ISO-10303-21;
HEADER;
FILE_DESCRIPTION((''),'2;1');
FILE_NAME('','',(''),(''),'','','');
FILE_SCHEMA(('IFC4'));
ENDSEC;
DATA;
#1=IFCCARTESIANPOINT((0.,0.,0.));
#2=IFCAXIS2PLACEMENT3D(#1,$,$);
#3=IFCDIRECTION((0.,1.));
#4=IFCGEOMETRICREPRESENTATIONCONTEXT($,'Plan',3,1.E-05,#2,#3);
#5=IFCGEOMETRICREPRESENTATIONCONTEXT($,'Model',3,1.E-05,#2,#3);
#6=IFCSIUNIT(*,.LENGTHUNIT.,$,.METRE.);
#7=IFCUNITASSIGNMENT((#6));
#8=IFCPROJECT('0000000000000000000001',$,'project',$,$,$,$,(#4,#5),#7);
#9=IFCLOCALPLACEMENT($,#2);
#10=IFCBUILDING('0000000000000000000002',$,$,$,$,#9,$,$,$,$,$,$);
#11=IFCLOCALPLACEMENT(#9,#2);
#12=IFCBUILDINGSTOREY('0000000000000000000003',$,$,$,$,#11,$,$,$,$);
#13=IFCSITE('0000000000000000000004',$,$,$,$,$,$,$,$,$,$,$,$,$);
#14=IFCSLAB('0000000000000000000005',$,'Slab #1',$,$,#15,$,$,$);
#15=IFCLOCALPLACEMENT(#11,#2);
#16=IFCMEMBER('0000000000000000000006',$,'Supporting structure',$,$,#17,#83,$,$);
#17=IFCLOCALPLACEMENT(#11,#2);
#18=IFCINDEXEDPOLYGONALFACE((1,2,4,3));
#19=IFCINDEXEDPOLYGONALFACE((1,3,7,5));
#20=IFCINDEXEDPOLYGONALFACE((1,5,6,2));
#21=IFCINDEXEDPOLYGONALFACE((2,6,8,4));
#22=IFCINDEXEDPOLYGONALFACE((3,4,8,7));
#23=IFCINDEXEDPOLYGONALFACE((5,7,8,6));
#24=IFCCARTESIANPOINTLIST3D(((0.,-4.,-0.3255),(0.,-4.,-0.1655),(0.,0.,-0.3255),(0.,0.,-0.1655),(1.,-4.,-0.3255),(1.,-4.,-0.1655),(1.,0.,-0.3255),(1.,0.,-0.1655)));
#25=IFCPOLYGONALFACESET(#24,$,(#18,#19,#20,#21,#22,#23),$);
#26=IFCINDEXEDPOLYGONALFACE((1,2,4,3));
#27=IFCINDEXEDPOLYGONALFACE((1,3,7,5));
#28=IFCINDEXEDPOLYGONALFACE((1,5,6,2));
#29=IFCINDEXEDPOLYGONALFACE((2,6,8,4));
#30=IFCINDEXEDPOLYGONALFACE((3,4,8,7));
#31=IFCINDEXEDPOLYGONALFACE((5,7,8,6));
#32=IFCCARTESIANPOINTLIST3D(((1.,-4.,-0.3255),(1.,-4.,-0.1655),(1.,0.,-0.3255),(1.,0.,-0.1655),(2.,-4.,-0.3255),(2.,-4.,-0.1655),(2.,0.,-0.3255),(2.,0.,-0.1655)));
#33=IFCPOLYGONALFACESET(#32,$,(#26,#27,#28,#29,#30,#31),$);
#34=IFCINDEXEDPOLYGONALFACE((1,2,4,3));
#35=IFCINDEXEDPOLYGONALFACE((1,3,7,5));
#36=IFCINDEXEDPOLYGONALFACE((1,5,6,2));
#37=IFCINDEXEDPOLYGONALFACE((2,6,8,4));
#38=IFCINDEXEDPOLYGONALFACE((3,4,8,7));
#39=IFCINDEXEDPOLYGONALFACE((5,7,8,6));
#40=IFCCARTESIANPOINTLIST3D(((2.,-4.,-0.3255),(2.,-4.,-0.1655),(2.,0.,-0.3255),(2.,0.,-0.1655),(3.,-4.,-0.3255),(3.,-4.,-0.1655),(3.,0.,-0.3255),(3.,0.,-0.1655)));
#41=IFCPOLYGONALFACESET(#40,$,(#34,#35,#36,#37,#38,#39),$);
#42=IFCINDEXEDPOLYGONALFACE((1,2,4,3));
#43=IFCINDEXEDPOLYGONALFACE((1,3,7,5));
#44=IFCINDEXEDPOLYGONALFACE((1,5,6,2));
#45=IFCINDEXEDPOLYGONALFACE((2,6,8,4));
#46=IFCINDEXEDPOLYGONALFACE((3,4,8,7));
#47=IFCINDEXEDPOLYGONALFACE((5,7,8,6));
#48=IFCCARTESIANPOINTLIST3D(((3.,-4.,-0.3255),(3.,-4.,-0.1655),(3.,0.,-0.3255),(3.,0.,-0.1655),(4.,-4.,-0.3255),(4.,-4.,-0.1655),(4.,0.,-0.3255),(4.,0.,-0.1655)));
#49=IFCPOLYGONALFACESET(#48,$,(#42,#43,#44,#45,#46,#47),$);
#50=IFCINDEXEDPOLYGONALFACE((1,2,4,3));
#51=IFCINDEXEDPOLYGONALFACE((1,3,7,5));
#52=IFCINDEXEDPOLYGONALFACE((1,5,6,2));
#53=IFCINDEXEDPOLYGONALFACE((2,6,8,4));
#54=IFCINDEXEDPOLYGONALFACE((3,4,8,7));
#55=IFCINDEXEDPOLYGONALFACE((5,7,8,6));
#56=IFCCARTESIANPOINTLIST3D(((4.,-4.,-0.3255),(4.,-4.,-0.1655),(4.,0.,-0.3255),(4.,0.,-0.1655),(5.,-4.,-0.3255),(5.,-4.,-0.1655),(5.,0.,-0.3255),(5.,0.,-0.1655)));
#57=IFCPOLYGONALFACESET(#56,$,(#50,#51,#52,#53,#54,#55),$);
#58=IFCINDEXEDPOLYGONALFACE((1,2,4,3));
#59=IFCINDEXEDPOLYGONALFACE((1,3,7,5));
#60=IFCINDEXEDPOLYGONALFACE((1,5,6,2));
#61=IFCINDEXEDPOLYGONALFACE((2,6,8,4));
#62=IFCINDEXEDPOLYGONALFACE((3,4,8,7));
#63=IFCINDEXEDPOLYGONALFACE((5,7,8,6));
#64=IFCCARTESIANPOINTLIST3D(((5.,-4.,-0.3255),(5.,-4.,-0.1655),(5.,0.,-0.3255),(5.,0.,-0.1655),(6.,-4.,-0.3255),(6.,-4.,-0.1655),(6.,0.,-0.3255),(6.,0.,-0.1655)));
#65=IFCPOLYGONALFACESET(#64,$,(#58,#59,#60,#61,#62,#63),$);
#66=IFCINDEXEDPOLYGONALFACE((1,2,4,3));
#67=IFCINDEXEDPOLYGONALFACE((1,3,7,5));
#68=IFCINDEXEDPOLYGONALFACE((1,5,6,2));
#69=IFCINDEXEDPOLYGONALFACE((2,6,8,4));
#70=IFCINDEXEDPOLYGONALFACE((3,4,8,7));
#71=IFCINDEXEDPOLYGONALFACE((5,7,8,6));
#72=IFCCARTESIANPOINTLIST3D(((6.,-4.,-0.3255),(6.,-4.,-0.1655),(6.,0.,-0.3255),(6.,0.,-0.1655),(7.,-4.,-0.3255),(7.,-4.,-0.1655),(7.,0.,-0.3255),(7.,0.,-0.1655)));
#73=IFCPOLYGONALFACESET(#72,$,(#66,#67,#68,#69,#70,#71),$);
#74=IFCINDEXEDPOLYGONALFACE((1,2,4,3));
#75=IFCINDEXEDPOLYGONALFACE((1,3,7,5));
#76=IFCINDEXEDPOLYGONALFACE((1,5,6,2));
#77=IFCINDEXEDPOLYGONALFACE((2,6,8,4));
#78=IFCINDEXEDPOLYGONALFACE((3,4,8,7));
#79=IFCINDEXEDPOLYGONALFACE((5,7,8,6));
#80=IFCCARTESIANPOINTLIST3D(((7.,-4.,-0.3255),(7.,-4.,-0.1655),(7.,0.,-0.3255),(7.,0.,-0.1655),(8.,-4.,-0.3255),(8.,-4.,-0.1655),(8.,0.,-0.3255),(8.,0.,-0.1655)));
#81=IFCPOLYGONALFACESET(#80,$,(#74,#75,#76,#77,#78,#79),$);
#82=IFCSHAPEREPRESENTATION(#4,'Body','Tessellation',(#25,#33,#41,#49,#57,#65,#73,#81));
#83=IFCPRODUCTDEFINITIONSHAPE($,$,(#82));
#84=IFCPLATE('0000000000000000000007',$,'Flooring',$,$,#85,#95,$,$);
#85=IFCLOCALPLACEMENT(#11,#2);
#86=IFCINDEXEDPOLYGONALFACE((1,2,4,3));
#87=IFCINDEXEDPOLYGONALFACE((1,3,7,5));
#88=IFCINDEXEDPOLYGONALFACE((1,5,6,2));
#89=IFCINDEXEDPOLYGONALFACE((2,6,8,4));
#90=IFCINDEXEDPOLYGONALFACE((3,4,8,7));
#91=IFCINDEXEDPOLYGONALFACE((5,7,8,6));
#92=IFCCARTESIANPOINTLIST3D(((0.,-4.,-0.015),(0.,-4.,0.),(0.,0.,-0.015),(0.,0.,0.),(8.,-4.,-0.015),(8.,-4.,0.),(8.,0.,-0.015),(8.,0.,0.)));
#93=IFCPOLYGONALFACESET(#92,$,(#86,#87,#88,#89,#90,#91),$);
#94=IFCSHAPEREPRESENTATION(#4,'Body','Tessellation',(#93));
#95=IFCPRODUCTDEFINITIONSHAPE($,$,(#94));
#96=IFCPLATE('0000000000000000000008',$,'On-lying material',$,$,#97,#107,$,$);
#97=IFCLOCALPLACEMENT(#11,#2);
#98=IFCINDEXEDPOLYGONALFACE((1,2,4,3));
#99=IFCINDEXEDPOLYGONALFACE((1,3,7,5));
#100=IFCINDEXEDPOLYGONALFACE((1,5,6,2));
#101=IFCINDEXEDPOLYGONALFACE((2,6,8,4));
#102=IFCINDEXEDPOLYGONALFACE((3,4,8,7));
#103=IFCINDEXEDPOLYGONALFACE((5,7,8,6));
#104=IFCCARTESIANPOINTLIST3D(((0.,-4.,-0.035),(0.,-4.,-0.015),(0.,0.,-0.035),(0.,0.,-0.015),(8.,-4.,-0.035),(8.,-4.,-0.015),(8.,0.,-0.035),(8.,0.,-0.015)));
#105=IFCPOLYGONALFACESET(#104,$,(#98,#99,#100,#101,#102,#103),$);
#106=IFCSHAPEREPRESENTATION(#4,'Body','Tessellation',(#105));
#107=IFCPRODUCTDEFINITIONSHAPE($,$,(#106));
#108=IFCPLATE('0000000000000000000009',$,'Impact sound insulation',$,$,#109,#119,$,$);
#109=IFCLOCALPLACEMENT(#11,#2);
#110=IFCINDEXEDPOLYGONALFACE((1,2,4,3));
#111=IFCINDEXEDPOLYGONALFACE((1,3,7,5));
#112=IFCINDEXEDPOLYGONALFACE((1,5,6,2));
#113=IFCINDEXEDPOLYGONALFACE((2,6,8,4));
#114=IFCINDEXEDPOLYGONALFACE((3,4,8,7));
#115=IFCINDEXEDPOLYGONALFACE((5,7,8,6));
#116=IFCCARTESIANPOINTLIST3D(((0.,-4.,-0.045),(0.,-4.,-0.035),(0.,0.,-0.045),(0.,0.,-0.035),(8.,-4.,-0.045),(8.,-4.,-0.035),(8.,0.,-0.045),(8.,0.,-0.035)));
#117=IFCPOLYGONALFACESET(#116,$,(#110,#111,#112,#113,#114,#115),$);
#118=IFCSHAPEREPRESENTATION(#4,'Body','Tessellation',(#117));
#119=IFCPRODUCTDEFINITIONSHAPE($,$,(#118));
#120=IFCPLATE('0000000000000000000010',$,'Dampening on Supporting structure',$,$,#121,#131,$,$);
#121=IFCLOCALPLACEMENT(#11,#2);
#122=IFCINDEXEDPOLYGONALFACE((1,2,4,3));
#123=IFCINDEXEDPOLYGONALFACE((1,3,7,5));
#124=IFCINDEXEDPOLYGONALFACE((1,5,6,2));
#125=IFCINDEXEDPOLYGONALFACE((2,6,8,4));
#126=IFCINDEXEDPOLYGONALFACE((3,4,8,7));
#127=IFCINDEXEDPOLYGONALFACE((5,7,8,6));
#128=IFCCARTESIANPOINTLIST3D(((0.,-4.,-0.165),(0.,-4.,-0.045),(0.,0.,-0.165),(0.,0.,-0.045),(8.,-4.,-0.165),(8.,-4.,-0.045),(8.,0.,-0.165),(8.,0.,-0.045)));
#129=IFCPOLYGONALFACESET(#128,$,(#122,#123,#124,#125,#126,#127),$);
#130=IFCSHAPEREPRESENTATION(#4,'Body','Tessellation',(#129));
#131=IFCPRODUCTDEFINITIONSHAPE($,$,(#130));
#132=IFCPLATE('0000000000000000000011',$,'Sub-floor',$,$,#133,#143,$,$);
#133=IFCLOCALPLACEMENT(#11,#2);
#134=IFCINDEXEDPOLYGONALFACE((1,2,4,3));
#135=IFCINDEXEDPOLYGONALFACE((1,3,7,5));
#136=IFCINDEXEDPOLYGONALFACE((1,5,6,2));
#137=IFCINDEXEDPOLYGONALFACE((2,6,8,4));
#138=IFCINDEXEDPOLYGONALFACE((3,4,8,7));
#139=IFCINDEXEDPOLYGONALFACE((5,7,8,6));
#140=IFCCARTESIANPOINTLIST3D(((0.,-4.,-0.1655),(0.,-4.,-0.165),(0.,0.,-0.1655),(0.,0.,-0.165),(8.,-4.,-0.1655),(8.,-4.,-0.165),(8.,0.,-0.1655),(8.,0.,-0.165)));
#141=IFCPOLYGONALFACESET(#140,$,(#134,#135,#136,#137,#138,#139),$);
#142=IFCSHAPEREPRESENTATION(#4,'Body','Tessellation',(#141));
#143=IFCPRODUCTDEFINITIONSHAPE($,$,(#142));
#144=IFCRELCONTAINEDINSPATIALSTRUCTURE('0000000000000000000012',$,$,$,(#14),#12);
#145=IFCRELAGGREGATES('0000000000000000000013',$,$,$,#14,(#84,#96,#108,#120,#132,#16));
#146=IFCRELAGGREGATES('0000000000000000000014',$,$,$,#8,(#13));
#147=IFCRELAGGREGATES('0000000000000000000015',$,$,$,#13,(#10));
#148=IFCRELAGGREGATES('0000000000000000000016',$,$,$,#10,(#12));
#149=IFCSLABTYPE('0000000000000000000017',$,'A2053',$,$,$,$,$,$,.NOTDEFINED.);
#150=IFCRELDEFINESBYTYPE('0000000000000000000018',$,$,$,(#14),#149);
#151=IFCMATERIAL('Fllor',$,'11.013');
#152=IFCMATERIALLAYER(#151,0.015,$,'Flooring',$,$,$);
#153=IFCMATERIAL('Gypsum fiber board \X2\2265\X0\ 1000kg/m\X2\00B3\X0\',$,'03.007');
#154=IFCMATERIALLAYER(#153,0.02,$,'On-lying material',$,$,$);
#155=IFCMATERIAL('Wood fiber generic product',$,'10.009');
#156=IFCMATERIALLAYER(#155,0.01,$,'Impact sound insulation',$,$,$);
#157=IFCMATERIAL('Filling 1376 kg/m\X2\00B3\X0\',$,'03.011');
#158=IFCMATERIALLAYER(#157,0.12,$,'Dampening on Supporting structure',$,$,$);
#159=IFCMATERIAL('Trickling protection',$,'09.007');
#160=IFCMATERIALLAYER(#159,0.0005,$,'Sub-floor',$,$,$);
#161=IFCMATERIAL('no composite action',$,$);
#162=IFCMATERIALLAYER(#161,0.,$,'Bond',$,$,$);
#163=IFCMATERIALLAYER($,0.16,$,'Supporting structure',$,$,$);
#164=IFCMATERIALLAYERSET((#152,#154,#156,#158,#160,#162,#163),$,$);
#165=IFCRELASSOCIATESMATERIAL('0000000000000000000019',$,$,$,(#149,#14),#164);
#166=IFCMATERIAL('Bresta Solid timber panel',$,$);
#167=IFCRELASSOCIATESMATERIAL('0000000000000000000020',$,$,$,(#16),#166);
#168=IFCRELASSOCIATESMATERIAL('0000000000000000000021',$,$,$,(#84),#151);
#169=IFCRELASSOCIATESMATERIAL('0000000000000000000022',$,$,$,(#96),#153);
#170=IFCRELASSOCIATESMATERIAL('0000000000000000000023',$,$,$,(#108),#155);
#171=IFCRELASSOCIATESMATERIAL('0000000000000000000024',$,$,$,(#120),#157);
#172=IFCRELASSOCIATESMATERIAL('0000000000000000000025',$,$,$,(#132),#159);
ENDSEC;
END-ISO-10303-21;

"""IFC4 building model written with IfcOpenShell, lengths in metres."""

from ifc_helpers import new_model, si_unit, direction, frame, frame_2d, origin, origin_with_axes, place, context, project, spatial, rectangle, extrude, material, layer, layer_set, type_object, element, aggregate, save


model = new_model("IFC4")

# Units and contexts
plan_context = context("Plan", 3, precision=1e-05, world=origin(), true_north=direction((0.0, 1.0)))
model_context = context("Model", 3, precision=1e-05, world=origin(), true_north=direction((0.0, 1.0)))
ifc_project = project(units=[si_unit("LENGTHUNIT", "METRE")], contexts=[plan_context, model_context])

# Site, building, storey
site = spatial("IfcSite", under=ifc_project)
building_placement = place(None, origin())
building = spatial("IfcBuilding", under=site, at=building_placement)
storey_placement = place(building_placement, origin())
storey = spatial("IfcBuildingStorey", under=building, at=storey_placement)

# Slab, member, plates
ifc_material_1 = material(Name="Fllor", Category="11.013")
ifc_layer_1 = layer(ifc_material_1, 0.015, Name="Flooring")
ifc_material_2 = material(Name="Gypsum fiber board ≥ 1000kg/m³", Category="03.007")
ifc_layer_2 = layer(ifc_material_2, 0.02, Name="On-lying material")
ifc_material_3 = material(Name="Wood fiber generic product", Category="10.009")
ifc_layer_3 = layer(ifc_material_3, 0.01, Name="Impact sound insulation")
ifc_material_4 = material(Name="Filling 1376 kg/m³", Category="03.011")
ifc_layer_4 = layer(ifc_material_4, 0.12, Name="Dampening on Supporting structure")
ifc_material_5 = material(Name="Trickling protection", Category="09.007")
ifc_layer_5 = layer(ifc_material_5, 0.0005, Name="Sub-floor")
ifc_material_6 = material(Name="no composite action")
ifc_layer_6 = layer(ifc_material_6, 0.0, Name="Bond")
ifc_layer_7 = layer(None, 0.16, Name="Supporting structure")
ifc_layer_set = layer_set([ifc_layer_1, ifc_layer_2, ifc_layer_3, ifc_layer_4, ifc_layer_5, ifc_layer_6, ifc_layer_7])
slab_type = type_object("IfcSlabType", Name="A2053", PredefinedType="NOTDEFINED", material=ifc_layer_set)
slab_placement = place(None, frame((0.0, 0.0, 0.0), z_axis=(0.0, 0.0, -1.0), x_axis=(1.0, 0.0, 0.0)))
slab = element("IfcSlab", 1, at=slab_placement, inside=storey, type_object=slab_type, material=ifc_layer_set, Name="Slab #1")
ifc_material_7 = material(Name="Bresta Solid timber panel")
member_placement = place(slab_placement, origin())
member = element("IfcMember", 2, at=member_placement, material=ifc_material_7, Name="Supporting structure", context=plan_context, shape_type="SweptSolid", body=[
    extrude(rectangle(XDim=1.0, YDim=0.16, at=frame_2d((0.5, 0.08), x_axis=(1.0, 0.0))), frame((0.0, 4.0, 0.1655), z_axis=(0.0, -1.0, 0.0), x_axis=(1.0, 0.0, 0.0)), (0.0, 0.0, 1.0), 4.0),
    extrude(rectangle(XDim=1.0, YDim=0.16, at=frame_2d((0.5, 0.08), x_axis=(1.0, 0.0))), frame((1.0, 4.0, 0.1655), z_axis=(0.0, -1.0, 0.0), x_axis=(1.0, 0.0, 0.0)), (0.0, 0.0, 1.0), 4.0),
    extrude(rectangle(XDim=1.0, YDim=0.16, at=frame_2d((0.5, 0.08), x_axis=(1.0, 0.0))), frame((2.0, 4.0, 0.1655), z_axis=(0.0, -1.0, 0.0), x_axis=(1.0, 0.0, 0.0)), (0.0, 0.0, 1.0), 4.0),
    extrude(rectangle(XDim=1.0, YDim=0.16, at=frame_2d((0.5, 0.08), x_axis=(1.0, 0.0))), frame((3.0, 4.0, 0.1655), z_axis=(0.0, -1.0, 0.0), x_axis=(1.0, 0.0, 0.0)), (0.0, 0.0, 1.0), 4.0),
    extrude(rectangle(XDim=1.0, YDim=0.16, at=frame_2d((0.5, 0.08), x_axis=(1.0, 0.0))), frame((4.0, 4.0, 0.1655), z_axis=(0.0, -1.0, 0.0), x_axis=(1.0, 0.0, 0.0)), (0.0, 0.0, 1.0), 4.0),
    extrude(rectangle(XDim=1.0, YDim=0.16, at=frame_2d((0.5, 0.08), x_axis=(1.0, 0.0))), frame((5.0, 4.0, 0.1655), z_axis=(0.0, -1.0, 0.0), x_axis=(1.0, 0.0, 0.0)), (0.0, 0.0, 1.0), 4.0),
    extrude(rectangle(XDim=1.0, YDim=0.16, at=frame_2d((0.5, 0.08), x_axis=(1.0, 0.0))), frame((6.0, 4.0, 0.1655), z_axis=(0.0, -1.0, 0.0), x_axis=(1.0, 0.0, 0.0)), (0.0, 0.0, 1.0), 4.0),
    extrude(rectangle(XDim=1.0, YDim=0.16, at=frame_2d((0.5, 0.08), x_axis=(1.0, 0.0))), frame((7.0, 4.0, 0.1655), z_axis=(0.0, -1.0, 0.0), x_axis=(1.0, 0.0, 0.0)), (0.0, 0.0, 1.0), 4.0),
])
plate_1_placement = place(slab_placement, origin())
plate_1 = element("IfcPlate", 3, at=plate_1_placement, material=ifc_material_1, Name="Flooring", context=plan_context, shape_type="SweptSolid", body=[
    extrude(rectangle(XDim=8.0, YDim=4.0, at=frame_2d((4.0, 2.0), x_axis=(1.0, 0.0))), origin_with_axes(), (0.0, 0.0, 1.0), 0.015),
])
plate_2_placement = place(slab_placement, origin())
plate_2 = element("IfcPlate", 4, at=plate_2_placement, material=ifc_material_2, Name="On-lying material", context=plan_context, shape_type="SweptSolid", body=[
    extrude(rectangle(XDim=8.0, YDim=4.0, at=frame_2d((4.0, 2.0), x_axis=(1.0, 0.0))), frame((0.0, 0.0, 0.015), z_axis=(0.0, 0.0, 1.0), x_axis=(1.0, 0.0, 0.0)), (0.0, 0.0, 1.0), 0.02),
])
plate_3_placement = place(slab_placement, origin())
plate_3 = element("IfcPlate", 5, at=plate_3_placement, material=ifc_material_3, Name="Impact sound insulation", context=plan_context, shape_type="SweptSolid", body=[
    extrude(rectangle(XDim=8.0, YDim=4.0, at=frame_2d((4.0, 2.0), x_axis=(1.0, 0.0))), frame((0.0, 0.0, 0.035), z_axis=(0.0, 0.0, 1.0), x_axis=(1.0, 0.0, 0.0)), (0.0, 0.0, 1.0), 0.01),
])
plate_4_placement = place(slab_placement, origin())
plate_4 = element("IfcPlate", 6, at=plate_4_placement, material=ifc_material_4, Name="Dampening on Supporting structure", context=plan_context, shape_type="SweptSolid", body=[
    extrude(rectangle(XDim=8.0, YDim=4.0, at=frame_2d((4.0, 2.0), x_axis=(1.0, 0.0))), frame((0.0, 0.0, 0.045), z_axis=(0.0, 0.0, 1.0), x_axis=(1.0, 0.0, 0.0)), (0.0, 0.0, 1.0), 0.12),
])
plate_5_placement = place(slab_placement, origin())
plate_5 = element("IfcPlate", 7, at=plate_5_placement, material=ifc_material_5, Name="Sub-floor", context=plan_context, shape_type="SweptSolid", body=[
    extrude(rectangle(XDim=8.0, YDim=4.0, at=frame_2d((4.0, 2.0), x_axis=(1.0, 0.0))), frame((0.0, 0.0, 0.165), z_axis=(0.0, 0.0, 1.0), x_axis=(1.0, 0.0, 0.0)), (0.0, 0.0, 1.0), 0.0005),
])
aggregate(slab, [plate_1, plate_2, plate_3, plate_4, plate_5, member])

save(model, "model.ifc")
